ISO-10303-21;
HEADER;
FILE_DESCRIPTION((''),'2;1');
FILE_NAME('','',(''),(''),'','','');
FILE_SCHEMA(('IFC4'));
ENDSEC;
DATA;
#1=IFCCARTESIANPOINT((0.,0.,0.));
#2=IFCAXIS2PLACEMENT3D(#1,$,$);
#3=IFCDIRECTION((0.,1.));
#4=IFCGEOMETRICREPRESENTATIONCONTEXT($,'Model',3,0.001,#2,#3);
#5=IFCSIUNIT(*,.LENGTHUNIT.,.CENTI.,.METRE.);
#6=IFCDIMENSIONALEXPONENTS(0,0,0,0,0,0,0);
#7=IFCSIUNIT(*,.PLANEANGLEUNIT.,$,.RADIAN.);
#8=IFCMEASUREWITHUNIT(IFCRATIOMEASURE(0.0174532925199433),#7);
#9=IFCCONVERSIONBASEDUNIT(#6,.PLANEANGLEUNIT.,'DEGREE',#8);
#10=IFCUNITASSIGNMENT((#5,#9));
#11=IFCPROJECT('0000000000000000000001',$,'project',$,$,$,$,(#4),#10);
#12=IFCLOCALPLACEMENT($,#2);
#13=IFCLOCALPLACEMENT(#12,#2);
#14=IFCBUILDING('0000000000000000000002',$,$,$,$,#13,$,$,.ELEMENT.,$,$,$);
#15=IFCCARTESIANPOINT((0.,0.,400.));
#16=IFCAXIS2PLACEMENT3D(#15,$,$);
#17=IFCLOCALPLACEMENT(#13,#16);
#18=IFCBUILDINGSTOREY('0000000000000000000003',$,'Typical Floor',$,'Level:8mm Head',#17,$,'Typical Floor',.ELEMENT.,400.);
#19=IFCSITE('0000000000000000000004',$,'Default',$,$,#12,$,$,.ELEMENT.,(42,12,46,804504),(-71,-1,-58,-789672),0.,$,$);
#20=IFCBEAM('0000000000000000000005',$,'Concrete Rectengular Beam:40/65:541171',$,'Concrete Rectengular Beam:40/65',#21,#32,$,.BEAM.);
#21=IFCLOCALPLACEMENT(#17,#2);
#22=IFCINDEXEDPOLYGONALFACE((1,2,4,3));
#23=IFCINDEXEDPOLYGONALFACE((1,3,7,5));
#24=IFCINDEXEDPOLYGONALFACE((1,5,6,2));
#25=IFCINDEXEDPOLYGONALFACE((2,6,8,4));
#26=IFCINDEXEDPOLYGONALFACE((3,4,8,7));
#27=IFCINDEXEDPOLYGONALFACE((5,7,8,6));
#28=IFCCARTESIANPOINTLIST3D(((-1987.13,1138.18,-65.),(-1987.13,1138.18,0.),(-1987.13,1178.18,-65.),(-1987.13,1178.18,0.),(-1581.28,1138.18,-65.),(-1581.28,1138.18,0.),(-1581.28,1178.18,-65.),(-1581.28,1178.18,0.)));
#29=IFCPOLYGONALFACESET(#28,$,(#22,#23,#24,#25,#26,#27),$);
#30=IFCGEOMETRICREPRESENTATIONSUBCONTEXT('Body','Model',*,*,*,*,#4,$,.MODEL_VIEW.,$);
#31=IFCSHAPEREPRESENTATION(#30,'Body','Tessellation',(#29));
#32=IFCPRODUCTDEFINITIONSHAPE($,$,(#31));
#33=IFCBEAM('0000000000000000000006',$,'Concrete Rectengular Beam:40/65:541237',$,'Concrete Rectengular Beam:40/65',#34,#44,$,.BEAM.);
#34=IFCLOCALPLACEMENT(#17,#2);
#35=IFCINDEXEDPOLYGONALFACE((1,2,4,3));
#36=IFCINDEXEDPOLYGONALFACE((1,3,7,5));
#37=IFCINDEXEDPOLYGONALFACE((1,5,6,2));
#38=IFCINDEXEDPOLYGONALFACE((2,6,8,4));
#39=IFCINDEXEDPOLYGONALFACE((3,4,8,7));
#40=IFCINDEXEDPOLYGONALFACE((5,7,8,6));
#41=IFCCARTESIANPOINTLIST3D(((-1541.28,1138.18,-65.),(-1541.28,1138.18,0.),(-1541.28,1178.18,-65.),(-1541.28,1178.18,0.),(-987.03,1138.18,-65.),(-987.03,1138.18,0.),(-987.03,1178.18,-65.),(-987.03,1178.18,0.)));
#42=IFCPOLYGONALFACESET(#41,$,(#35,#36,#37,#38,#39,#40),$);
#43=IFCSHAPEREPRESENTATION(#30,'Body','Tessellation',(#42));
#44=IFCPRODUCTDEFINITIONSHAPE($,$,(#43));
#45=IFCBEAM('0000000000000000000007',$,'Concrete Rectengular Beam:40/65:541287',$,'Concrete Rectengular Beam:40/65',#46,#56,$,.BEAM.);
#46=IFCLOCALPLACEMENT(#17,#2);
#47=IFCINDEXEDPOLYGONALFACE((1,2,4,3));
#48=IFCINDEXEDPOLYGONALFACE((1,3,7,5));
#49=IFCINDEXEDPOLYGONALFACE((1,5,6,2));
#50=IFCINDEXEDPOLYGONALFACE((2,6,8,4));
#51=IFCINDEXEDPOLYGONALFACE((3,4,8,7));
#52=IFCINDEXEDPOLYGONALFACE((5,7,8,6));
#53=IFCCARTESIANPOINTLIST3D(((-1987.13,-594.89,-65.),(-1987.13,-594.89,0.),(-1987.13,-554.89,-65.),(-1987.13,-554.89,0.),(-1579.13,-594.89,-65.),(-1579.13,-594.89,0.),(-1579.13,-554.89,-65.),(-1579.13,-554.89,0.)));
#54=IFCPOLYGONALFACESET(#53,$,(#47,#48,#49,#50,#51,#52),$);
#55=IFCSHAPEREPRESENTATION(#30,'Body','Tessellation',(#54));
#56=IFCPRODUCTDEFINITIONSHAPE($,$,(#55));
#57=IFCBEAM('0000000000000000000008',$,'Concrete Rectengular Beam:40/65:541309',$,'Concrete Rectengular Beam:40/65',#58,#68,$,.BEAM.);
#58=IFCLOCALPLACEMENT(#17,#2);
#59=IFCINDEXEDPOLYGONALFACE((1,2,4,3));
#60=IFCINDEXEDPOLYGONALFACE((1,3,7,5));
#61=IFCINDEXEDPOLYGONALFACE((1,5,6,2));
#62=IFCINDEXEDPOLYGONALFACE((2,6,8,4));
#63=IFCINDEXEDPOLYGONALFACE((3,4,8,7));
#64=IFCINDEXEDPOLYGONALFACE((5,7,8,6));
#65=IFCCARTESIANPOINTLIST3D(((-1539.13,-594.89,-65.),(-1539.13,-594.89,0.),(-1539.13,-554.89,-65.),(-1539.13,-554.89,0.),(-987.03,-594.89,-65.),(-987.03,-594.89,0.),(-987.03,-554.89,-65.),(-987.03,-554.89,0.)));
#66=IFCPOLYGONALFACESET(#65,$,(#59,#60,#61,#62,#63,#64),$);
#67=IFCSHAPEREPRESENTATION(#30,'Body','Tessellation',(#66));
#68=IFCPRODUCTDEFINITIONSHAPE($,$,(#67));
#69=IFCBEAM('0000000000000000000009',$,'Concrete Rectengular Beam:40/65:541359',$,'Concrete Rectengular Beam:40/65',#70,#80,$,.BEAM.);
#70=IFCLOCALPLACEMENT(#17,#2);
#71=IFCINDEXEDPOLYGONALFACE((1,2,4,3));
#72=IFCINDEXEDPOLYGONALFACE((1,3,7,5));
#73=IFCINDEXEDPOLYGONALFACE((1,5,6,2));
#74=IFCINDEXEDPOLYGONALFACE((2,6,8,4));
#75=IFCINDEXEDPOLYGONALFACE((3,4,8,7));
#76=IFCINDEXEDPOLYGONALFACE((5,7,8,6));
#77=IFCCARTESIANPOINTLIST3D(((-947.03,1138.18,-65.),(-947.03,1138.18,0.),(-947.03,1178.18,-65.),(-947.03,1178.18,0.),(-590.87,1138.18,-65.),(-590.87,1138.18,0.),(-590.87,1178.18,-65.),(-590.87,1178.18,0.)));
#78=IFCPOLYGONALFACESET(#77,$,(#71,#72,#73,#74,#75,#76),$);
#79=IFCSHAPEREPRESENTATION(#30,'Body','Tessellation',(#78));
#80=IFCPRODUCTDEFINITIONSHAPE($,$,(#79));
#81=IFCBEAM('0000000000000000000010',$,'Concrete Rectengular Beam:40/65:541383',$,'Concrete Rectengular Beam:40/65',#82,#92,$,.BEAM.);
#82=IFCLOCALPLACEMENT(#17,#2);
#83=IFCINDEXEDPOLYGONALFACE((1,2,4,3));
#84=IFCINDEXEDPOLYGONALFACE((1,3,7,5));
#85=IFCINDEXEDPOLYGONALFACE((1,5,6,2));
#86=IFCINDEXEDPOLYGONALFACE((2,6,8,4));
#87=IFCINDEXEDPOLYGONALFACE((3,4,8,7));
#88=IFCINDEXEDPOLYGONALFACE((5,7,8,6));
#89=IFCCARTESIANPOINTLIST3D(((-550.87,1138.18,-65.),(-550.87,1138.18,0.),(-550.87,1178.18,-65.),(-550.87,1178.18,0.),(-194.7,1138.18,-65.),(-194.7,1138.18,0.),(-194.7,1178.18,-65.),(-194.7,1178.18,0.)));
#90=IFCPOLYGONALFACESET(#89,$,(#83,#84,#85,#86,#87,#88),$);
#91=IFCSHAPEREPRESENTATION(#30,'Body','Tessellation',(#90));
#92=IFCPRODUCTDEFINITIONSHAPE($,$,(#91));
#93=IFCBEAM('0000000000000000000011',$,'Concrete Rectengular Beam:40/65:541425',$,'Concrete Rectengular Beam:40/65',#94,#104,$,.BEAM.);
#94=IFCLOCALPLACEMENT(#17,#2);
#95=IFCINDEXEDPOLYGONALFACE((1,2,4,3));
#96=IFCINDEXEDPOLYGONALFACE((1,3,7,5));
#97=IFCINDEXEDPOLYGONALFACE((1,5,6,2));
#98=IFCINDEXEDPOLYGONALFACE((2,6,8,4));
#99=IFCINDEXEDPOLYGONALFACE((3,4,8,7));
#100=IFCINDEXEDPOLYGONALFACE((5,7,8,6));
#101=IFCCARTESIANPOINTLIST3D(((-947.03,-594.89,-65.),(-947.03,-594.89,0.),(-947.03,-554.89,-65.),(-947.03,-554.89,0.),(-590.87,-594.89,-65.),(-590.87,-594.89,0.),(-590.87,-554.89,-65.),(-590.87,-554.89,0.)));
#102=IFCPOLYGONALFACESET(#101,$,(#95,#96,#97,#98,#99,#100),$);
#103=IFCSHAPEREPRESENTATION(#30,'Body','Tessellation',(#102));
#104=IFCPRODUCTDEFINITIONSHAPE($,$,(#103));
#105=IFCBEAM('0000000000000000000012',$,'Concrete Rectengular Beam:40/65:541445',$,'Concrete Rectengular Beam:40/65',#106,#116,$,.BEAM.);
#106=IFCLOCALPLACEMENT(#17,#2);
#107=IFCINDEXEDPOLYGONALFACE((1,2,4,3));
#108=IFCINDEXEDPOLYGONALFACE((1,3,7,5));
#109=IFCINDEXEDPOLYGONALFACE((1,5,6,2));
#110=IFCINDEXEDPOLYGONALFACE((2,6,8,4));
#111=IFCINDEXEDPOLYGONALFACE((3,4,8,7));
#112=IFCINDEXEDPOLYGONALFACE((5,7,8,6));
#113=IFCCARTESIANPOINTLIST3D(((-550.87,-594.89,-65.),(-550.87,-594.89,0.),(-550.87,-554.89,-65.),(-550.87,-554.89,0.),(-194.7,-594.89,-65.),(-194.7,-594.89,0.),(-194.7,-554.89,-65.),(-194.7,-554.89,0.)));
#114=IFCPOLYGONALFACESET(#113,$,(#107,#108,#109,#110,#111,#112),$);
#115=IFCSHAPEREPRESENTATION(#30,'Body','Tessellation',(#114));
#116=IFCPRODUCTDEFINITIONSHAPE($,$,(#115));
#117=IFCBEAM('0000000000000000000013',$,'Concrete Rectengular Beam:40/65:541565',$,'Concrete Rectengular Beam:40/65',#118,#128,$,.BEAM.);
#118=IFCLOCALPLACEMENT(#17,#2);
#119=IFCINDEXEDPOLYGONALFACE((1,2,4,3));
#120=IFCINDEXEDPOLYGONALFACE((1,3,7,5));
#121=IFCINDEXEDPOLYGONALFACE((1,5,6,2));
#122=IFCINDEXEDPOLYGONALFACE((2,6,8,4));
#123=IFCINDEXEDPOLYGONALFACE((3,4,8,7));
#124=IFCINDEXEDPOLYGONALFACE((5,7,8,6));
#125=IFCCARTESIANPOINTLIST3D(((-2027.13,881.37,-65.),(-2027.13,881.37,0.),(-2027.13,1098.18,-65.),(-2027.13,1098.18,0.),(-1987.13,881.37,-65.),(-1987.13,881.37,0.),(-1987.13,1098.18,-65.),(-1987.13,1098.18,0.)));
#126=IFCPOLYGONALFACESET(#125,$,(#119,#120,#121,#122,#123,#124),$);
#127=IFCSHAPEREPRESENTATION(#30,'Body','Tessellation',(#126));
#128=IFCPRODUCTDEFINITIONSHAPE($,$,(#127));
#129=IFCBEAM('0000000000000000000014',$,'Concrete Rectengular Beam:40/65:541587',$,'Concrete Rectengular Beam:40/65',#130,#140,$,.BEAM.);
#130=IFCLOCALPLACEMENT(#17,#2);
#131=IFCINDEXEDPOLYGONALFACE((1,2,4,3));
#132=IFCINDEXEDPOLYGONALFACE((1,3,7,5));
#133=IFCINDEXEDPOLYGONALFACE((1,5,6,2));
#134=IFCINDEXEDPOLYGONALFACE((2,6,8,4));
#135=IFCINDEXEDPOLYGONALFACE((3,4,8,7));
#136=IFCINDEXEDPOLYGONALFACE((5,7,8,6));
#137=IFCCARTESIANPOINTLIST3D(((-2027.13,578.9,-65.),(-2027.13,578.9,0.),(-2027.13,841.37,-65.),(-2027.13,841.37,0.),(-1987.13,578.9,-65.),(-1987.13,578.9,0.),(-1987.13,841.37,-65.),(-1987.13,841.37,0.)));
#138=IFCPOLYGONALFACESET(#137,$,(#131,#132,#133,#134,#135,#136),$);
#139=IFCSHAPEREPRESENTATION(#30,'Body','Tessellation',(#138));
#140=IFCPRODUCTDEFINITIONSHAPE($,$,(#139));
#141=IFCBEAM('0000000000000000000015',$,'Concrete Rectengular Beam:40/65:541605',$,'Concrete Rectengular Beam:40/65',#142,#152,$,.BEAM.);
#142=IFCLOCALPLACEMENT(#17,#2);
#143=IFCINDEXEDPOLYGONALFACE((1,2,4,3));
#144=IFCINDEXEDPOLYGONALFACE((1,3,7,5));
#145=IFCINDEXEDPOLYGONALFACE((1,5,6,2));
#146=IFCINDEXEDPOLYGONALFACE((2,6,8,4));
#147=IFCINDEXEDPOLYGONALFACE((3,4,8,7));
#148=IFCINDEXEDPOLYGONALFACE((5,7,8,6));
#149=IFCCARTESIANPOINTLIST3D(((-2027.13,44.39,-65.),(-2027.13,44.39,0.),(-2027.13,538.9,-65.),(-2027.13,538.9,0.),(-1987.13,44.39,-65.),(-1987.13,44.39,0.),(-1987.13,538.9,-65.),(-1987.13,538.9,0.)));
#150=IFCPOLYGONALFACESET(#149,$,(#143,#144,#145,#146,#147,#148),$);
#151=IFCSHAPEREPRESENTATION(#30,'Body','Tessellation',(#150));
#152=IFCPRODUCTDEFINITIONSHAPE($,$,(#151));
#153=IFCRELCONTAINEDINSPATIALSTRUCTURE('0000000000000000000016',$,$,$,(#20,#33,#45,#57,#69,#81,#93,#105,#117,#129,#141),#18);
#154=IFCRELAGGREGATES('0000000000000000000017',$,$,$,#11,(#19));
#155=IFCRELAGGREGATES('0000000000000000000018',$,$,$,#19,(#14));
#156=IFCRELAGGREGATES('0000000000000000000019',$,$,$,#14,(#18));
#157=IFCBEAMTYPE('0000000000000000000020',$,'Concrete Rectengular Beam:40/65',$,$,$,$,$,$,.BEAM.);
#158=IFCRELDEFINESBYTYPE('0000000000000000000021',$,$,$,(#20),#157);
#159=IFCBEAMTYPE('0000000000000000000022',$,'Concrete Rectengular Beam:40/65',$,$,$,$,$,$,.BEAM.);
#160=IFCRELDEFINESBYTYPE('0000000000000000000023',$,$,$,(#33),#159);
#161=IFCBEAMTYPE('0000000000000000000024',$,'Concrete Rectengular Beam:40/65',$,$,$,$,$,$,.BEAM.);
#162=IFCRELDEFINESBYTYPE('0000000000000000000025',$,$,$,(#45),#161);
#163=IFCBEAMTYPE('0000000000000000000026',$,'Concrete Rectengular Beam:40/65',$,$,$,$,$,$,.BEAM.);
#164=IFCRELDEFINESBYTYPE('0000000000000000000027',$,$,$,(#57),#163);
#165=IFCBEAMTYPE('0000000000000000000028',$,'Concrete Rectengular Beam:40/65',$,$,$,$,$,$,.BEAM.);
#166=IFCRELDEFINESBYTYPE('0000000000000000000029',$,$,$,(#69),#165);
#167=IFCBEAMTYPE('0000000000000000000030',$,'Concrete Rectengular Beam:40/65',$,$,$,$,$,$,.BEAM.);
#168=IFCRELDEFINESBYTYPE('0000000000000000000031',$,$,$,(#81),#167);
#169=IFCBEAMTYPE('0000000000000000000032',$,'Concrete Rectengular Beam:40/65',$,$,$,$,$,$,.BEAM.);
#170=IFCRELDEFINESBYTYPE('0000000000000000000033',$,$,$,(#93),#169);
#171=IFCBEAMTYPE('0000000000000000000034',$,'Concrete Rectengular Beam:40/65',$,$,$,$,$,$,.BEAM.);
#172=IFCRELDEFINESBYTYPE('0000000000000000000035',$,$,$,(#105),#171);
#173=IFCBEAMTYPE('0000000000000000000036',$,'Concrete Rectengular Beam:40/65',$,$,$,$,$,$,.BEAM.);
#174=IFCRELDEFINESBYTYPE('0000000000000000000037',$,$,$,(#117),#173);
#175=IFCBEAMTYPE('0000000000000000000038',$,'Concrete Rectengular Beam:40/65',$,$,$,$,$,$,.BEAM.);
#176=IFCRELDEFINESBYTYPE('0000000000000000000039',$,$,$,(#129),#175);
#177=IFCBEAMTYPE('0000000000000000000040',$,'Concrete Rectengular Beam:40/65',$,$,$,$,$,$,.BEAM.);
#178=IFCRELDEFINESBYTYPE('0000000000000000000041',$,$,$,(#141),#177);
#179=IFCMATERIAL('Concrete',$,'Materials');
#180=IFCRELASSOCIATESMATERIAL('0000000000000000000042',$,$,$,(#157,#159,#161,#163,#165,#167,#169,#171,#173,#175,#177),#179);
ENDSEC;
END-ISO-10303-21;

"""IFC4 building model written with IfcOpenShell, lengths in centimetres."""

from ifc_helpers import new_model, entity, si_unit, converted_unit, direction, frame, origin, place, context, subcontext, project, spatial, indexed_curve, outline, extrude, source, transform, mapped, material, type_object, type_shapes, element, save


model = new_model("IFC4")

# Units and contexts
model_context = context("Model", 3, precision=0.001, world=origin(), true_north=direction((0.0, 1.0)))
body_context = subcontext(model_context, "Body", "Model", "MODEL_VIEW")
ifc_project = project(units=[si_unit("LENGTHUNIT", "METRE", prefix="CENTI"), converted_unit("PLANEANGLEUNIT", "DEGREE", entity("IfcRatioMeasure", 0.0174532925199433), si_unit("PLANEANGLEUNIT", "RADIAN"), dimensions=[0, 0, 0, 0, 0, 0, 0])], contexts=[model_context])

# Site, building, storey
site_placement = place(None, origin())
site = spatial("IfcSite", under=ifc_project, at=site_placement, Name="Default", CompositionType="ELEMENT", RefLatitude=(42, 12, 46, 804504), RefLongitude=(-71, -1, -58, -789672), RefElevation=0.0)
building_placement = place(site_placement, origin())
building = spatial("IfcBuilding", under=site, at=building_placement, CompositionType="ELEMENT")
storey_placement = place(building_placement, frame((0.0, 0.0, 400.0)))
storey = spatial("IfcBuildingStorey", under=building, at=storey_placement, Name="Typical Floor", ObjectType="Level:8mm Head", LongName="Typical Floor", CompositionType="ELEMENT", Elevation=400.0)

# Beams
ifc_material = material(Name="Concrete", Category="Materials")
beam_type_1 = type_object("IfcBeamType", Name="Concrete Rectengular Beam:40/65", PredefinedType="BEAM", material=ifc_material)
shared_shape_1 = source(origin(), body_context, "Body", "SweptSolid", [
    extrude(outline(indexed_curve([(-32.5, -20.0), (32.5, -20.0), (32.5, 20.0), (-32.5, 20.0), (-32.5, -20.0)], self_intersect=False)), frame((-1581.28, 1158.18, 367.5), z_axis=(-1.0, 0.0, 0.0), x_axis=(0.0, 0.0, -1.0)), (0.0, 0.0, 1.0), 405.84),
])
type_shapes(beam_type_1, [shared_shape_1])
beam_1_placement = place(storey_placement, frame((0.0, 0.0, -400.0)))
element("IfcBeam", 1, at=beam_1_placement, inside=storey, type_object=beam_type_1, Name="Concrete Rectengular Beam:40/65:541171", ObjectType="Concrete Rectengular Beam:40/65", PredefinedType="BEAM", context=body_context, shape_type="MappedRepresentation", body=[
    mapped(shared_shape_1, transform((0.0, 0.0, 0.0), scale=1.0)),
])
beam_type_2 = type_object("IfcBeamType", Name="Concrete Rectengular Beam:40/65", PredefinedType="BEAM", material=ifc_material)
shared_shape_2 = source(origin(), body_context, "Body", "SweptSolid", [
    extrude(outline(indexed_curve([(-32.5, -20.0), (32.5, -20.0), (32.5, 20.0), (-32.5, 20.0), (-32.5, -20.0)], self_intersect=False)), frame((-1541.28, 1158.18, 367.5), z_axis=(1.0, 0.0, 0.0), x_axis=(0.0, 0.0, -1.0)), (0.0, 0.0, 1.0), 554.25),
])
type_shapes(beam_type_2, [shared_shape_2])
beam_2_placement = place(storey_placement, frame((0.0, 0.0, -400.0)))
element("IfcBeam", 2, at=beam_2_placement, inside=storey, type_object=beam_type_2, Name="Concrete Rectengular Beam:40/65:541237", ObjectType="Concrete Rectengular Beam:40/65", PredefinedType="BEAM", context=body_context, shape_type="MappedRepresentation", body=[
    mapped(shared_shape_2, transform((0.0, 0.0, 0.0), scale=1.0)),
])
beam_type_3 = type_object("IfcBeamType", Name="Concrete Rectengular Beam:40/65", PredefinedType="BEAM", material=ifc_material)
shared_shape_3 = source(origin(), body_context, "Body", "SweptSolid", [
    extrude(outline(indexed_curve([(-32.5, -20.0), (32.5, -20.0), (32.5, 20.0), (-32.5, 20.0), (-32.5, -20.0)], self_intersect=False)), frame((-1987.13, -574.89, 367.5), z_axis=(1.0, 0.0, 0.0), x_axis=(0.0, 0.0, -1.0)), (0.0, 0.0, 1.0), 408.0),
])
type_shapes(beam_type_3, [shared_shape_3])
beam_3_placement = place(storey_placement, frame((0.0, 0.0, -400.0)))
element("IfcBeam", 3, at=beam_3_placement, inside=storey, type_object=beam_type_3, Name="Concrete Rectengular Beam:40/65:541287", ObjectType="Concrete Rectengular Beam:40/65", PredefinedType="BEAM", context=body_context, shape_type="MappedRepresentation", body=[
    mapped(shared_shape_3, transform((0.0, 0.0, 0.0), scale=1.0)),
])
beam_type_4 = type_object("IfcBeamType", Name="Concrete Rectengular Beam:40/65", PredefinedType="BEAM", material=ifc_material)
shared_shape_4 = source(origin(), body_context, "Body", "SweptSolid", [
    extrude(outline(indexed_curve([(-32.5, -20.0), (32.5, -20.0), (32.5, 20.0), (-32.5, 20.0), (-32.5, -20.0)], self_intersect=False)), frame((-1539.13, -574.89, 367.5), z_axis=(1.0, 0.0, 0.0), x_axis=(0.0, 0.0, -1.0)), (0.0, 0.0, 1.0), 552.09),
])
type_shapes(beam_type_4, [shared_shape_4])
beam_4_placement = place(storey_placement, frame((0.0, 0.0, -400.0)))
element("IfcBeam", 4, at=beam_4_placement, inside=storey, type_object=beam_type_4, Name="Concrete Rectengular Beam:40/65:541309", ObjectType="Concrete Rectengular Beam:40/65", PredefinedType="BEAM", context=body_context, shape_type="MappedRepresentation", body=[
    mapped(shared_shape_4, transform((0.0, 0.0, 0.0), scale=1.0)),
])
beam_type_5 = type_object("IfcBeamType", Name="Concrete Rectengular Beam:40/65", PredefinedType="BEAM", material=ifc_material)
shared_shape_5 = source(origin(), body_context, "Body", "SweptSolid", [
    extrude(outline(indexed_curve([(-32.5, -20.0), (32.5, -20.0), (32.5, 20.0), (-32.5, 20.0), (-32.5, -20.0)], self_intersect=False)), frame((-947.03, 1158.18, 367.5), z_axis=(1.0, 0.0, 0.0), x_axis=(0.0, 0.0, -1.0)), (0.0, 0.0, 1.0), 356.17),
])
type_shapes(beam_type_5, [shared_shape_5])
beam_5_placement = place(storey_placement, frame((0.0, 0.0, -400.0)))
element("IfcBeam", 5, at=beam_5_placement, inside=storey, type_object=beam_type_5, Name="Concrete Rectengular Beam:40/65:541359", ObjectType="Concrete Rectengular Beam:40/65", PredefinedType="BEAM", context=body_context, shape_type="MappedRepresentation", body=[
    mapped(shared_shape_5, transform((0.0, 0.0, 0.0), scale=1.0)),
])
beam_type_6 = type_object("IfcBeamType", Name="Concrete Rectengular Beam:40/65", PredefinedType="BEAM", material=ifc_material)
shared_shape_6 = source(origin(), body_context, "Body", "SweptSolid", [
    extrude(outline(indexed_curve([(-32.5, -20.0), (32.5, -20.0), (32.5, 20.0), (-32.5, 20.0), (-32.5, -20.0)], self_intersect=False)), frame((-550.87, 1158.18, 367.5), z_axis=(1.0, 0.0, 0.0), x_axis=(0.0, 0.0, -1.0)), (0.0, 0.0, 1.0), 356.17),
])
type_shapes(beam_type_6, [shared_shape_6])
beam_6_placement = place(storey_placement, frame((0.0, 0.0, -400.0)))
element("IfcBeam", 6, at=beam_6_placement, inside=storey, type_object=beam_type_6, Name="Concrete Rectengular Beam:40/65:541383", ObjectType="Concrete Rectengular Beam:40/65", PredefinedType="BEAM", context=body_context, shape_type="MappedRepresentation", body=[
    mapped(shared_shape_6, transform((0.0, 0.0, 0.0), scale=1.0)),
])
beam_type_7 = type_object("IfcBeamType", Name="Concrete Rectengular Beam:40/65", PredefinedType="BEAM", material=ifc_material)
shared_shape_7 = source(origin(), body_context, "Body", "SweptSolid", [
    extrude(outline(indexed_curve([(-32.5, -20.0), (32.5, -20.0), (32.5, 20.0), (-32.5, 20.0), (-32.5, -20.0)], self_intersect=False)), frame((-947.03, -574.89, 367.5), z_axis=(1.0, 0.0, 0.0), x_axis=(0.0, 0.0, -1.0)), (0.0, 0.0, 1.0), 356.17),
])
type_shapes(beam_type_7, [shared_shape_7])
beam_7_placement = place(storey_placement, frame((0.0, 0.0, -400.0)))
element("IfcBeam", 7, at=beam_7_placement, inside=storey, type_object=beam_type_7, Name="Concrete Rectengular Beam:40/65:541425", ObjectType="Concrete Rectengular Beam:40/65", PredefinedType="BEAM", context=body_context, shape_type="MappedRepresentation", body=[
    mapped(shared_shape_7, transform((0.0, 0.0, 0.0), scale=1.0)),
])
beam_type_8 = type_object("IfcBeamType", Name="Concrete Rectengular Beam:40/65", PredefinedType="BEAM", material=ifc_material)
shared_shape_8 = source(origin(), body_context, "Body", "SweptSolid", [
    extrude(outline(indexed_curve([(-32.5, -20.0), (32.5, -20.0), (32.5, 20.0), (-32.5, 20.0), (-32.5, -20.0)], self_intersect=False)), frame((-550.87, -574.89, 367.5), z_axis=(1.0, 0.0, 0.0), x_axis=(0.0, 0.0, -1.0)), (0.0, 0.0, 1.0), 356.17),
])
type_shapes(beam_type_8, [shared_shape_8])
beam_8_placement = place(storey_placement, frame((0.0, 0.0, -400.0)))
element("IfcBeam", 8, at=beam_8_placement, inside=storey, type_object=beam_type_8, Name="Concrete Rectengular Beam:40/65:541445", ObjectType="Concrete Rectengular Beam:40/65", PredefinedType="BEAM", context=body_context, shape_type="MappedRepresentation", body=[
    mapped(shared_shape_8, transform((0.0, 0.0, 0.0), scale=1.0)),
])
beam_type_9 = type_object("IfcBeamType", Name="Concrete Rectengular Beam:40/65", PredefinedType="BEAM", material=ifc_material)
shared_shape_9 = source(origin(), body_context, "Body", "SweptSolid", [
    extrude(outline(indexed_curve([(-20.0, -32.5), (20.0, -32.5), (20.0, 32.5), (-20.0, 32.5), (-20.0, -32.5)], self_intersect=False)), frame((-2007.13, 1098.18, 367.5), z_axis=(0.0, -1.0, 0.0), x_axis=(-1.0, 0.0, 0.0)), (0.0, 0.0, 1.0), 216.81),
])
type_shapes(beam_type_9, [shared_shape_9])
beam_9_placement = place(storey_placement, frame((0.0, 0.0, -400.0)))
element("IfcBeam", 9, at=beam_9_placement, inside=storey, type_object=beam_type_9, Name="Concrete Rectengular Beam:40/65:541565", ObjectType="Concrete Rectengular Beam:40/65", PredefinedType="BEAM", context=body_context, shape_type="MappedRepresentation", body=[
    mapped(shared_shape_9, transform((0.0, 0.0, 0.0), scale=1.0)),
])
beam_type_10 = type_object("IfcBeamType", Name="Concrete Rectengular Beam:40/65", PredefinedType="BEAM", material=ifc_material)
shared_shape_10 = source(origin(), body_context, "Body", "SweptSolid", [
    extrude(outline(indexed_curve([(-20.0, -32.5), (20.0, -32.5), (20.0, 32.5), (-20.0, 32.5), (-20.0, -32.5)], self_intersect=False)), frame((-2007.13, 841.37, 367.5), z_axis=(0.0, -1.0, 0.0), x_axis=(-1.0, 0.0, 0.0)), (0.0, 0.0, 1.0), 262.47),
])
type_shapes(beam_type_10, [shared_shape_10])
beam_10_placement = place(storey_placement, frame((0.0, 0.0, -400.0)))
element("IfcBeam", 10, at=beam_10_placement, inside=storey, type_object=beam_type_10, Name="Concrete Rectengular Beam:40/65:541587", ObjectType="Concrete Rectengular Beam:40/65", PredefinedType="BEAM", context=body_context, shape_type="MappedRepresentation", body=[
    mapped(shared_shape_10, transform((0.0, 0.0, 0.0), scale=1.0)),
])
beam_type_11 = type_object("IfcBeamType", Name="Concrete Rectengular Beam:40/65", PredefinedType="BEAM", material=ifc_material)
shared_shape_11 = source(origin(), body_context, "Body", "SweptSolid", [
    extrude(outline(indexed_curve([(-20.0, -32.5), (20.0, -32.5), (20.0, 32.5), (-20.0, 32.5), (-20.0, -32.5)], self_intersect=False)), frame((-2007.13, 538.9, 367.5), z_axis=(0.0, -1.0, 0.0), x_axis=(-1.0, 0.0, 0.0)), (0.0, 0.0, 1.0), 494.51),
])
type_shapes(beam_type_11, [shared_shape_11])
beam_11_placement = place(storey_placement, frame((0.0, 0.0, -400.0)))
element("IfcBeam", 11, at=beam_11_placement, inside=storey, type_object=beam_type_11, Name="Concrete Rectengular Beam:40/65:541605", ObjectType="Concrete Rectengular Beam:40/65", PredefinedType="BEAM", context=body_context, shape_type="MappedRepresentation", body=[
    mapped(shared_shape_11, transform((0.0, 0.0, 0.0), scale=1.0)),
])

save(model, "model.ifc")
